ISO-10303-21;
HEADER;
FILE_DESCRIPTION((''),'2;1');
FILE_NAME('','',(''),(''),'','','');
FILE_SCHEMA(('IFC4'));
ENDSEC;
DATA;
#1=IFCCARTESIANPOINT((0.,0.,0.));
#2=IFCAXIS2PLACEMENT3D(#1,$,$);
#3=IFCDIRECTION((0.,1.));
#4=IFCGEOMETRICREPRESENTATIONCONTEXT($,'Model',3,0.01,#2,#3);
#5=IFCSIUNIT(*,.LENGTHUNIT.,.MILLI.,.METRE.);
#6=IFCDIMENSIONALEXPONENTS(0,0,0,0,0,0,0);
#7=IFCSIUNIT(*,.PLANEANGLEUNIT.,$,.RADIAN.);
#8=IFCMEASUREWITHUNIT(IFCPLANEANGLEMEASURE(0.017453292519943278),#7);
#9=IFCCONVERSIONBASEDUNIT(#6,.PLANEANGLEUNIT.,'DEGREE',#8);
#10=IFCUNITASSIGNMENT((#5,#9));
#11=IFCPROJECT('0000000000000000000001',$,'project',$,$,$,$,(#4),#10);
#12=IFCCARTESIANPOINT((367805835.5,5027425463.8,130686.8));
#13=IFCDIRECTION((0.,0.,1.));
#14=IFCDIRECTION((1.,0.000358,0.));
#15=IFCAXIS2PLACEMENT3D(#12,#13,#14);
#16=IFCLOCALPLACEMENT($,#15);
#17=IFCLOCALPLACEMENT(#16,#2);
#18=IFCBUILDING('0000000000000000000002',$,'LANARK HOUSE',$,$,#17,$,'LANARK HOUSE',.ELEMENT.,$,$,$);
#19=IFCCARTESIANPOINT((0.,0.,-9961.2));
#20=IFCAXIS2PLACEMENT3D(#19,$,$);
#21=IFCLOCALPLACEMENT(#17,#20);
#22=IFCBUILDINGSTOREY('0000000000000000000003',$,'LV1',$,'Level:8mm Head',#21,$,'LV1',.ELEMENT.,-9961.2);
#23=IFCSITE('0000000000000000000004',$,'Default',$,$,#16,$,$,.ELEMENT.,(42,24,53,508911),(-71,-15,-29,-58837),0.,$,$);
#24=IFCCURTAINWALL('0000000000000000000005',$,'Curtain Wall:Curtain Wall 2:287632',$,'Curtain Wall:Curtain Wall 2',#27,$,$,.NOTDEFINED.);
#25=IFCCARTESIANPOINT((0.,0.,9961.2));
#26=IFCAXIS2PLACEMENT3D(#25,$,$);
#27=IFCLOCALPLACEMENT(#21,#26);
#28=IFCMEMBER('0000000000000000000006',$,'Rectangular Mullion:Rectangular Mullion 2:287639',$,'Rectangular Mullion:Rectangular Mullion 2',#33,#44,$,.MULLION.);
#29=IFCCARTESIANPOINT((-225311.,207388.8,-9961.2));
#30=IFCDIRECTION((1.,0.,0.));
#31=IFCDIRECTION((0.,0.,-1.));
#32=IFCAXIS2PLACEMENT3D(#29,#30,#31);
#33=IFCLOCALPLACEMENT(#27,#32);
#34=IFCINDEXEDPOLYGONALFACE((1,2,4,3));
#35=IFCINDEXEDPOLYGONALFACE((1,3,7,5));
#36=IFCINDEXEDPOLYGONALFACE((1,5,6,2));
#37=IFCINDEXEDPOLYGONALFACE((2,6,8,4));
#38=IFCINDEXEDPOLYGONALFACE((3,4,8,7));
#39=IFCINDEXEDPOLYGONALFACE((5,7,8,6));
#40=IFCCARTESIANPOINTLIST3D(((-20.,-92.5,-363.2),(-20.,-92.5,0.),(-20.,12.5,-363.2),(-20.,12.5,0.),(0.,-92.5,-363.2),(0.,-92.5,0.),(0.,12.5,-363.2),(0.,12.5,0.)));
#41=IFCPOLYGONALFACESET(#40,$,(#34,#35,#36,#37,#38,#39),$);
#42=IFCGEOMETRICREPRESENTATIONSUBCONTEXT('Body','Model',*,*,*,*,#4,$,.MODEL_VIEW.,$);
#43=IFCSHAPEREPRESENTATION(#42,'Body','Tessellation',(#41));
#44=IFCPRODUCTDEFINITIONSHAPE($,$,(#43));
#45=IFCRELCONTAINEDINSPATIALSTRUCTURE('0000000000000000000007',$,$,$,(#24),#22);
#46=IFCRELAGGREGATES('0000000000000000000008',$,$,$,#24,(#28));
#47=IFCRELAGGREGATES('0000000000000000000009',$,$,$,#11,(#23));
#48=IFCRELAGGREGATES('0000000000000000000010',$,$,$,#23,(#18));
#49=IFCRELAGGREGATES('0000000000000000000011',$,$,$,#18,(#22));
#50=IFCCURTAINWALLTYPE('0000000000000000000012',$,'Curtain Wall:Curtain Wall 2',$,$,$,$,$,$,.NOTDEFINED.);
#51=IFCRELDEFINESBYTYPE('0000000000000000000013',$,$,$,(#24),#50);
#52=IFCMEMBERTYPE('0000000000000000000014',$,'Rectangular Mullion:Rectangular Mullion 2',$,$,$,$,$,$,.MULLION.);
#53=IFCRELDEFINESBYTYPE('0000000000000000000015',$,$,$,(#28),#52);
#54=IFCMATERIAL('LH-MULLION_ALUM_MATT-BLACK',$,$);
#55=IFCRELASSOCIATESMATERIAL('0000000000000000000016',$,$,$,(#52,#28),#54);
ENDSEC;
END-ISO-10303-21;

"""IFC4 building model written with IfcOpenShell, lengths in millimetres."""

from ifc_helpers import new_model, entity, si_unit, converted_unit, direction, frame, origin, place, context, subcontext, project, spatial, indexed_curve, outline, extrude, source, transform, mapped, material, type_object, type_shapes, element, aggregate, save


model = new_model("IFC4")

# Units and contexts
model_context = context("Model", 3, precision=0.01, world=origin(), true_north=direction((0.0, 1.0)))
body_context = subcontext(model_context, "Body", "Model", "MODEL_VIEW")
ifc_project = project(units=[si_unit("LENGTHUNIT", "METRE", prefix="MILLI"), converted_unit("PLANEANGLEUNIT", "DEGREE", entity("IfcPlaneAngleMeasure", 0.017453292519943278), si_unit("PLANEANGLEUNIT", "RADIAN"), dimensions=[0, 0, 0, 0, 0, 0, 0])], contexts=[model_context])

# Site, building, storey
site_placement = place(None, frame((367805835.5, 5027425463.8, 130686.8), z_axis=(0.0, 0.0, 1.0), x_axis=(1.0, 0.000358, 0.0)))
site = spatial("IfcSite", under=ifc_project, at=site_placement, Name="Default", CompositionType="ELEMENT", RefLatitude=(42, 24, 53, 508911), RefLongitude=(-71, -15, -29, -58837), RefElevation=0.0)
building_placement = place(site_placement, origin())
building = spatial("IfcBuilding", under=site, at=building_placement, Name="LANARK HOUSE", LongName="LANARK HOUSE", CompositionType="ELEMENT")
storey_placement = place(building_placement, frame((0.0, 0.0, -9961.2)))
storey = spatial("IfcBuildingStorey", under=building, at=storey_placement, Name="LV1", ObjectType="Level:8mm Head", LongName="LV1", CompositionType="ELEMENT", Elevation=-9961.2)

# Curtain wall
curtain_wall_type_1 = type_object("IfcCurtainWallType", Name="Curtain Wall:Curtain Wall 2", PredefinedType="NOTDEFINED")
curtain_wall_1_placement = place(storey_placement, frame((0.0, 0.0, 9961.2)))
curtain_wall_1 = element("IfcCurtainWall", 1, at=curtain_wall_1_placement, inside=storey, type_object=curtain_wall_type_1, Name="Curtain Wall:Curtain Wall 2:287632", ObjectType="Curtain Wall:Curtain Wall 2", PredefinedType="NOTDEFINED")
ifc_material_1 = material(Name="LH-MULLION_ALUM_MATT-BLACK")

# Member
member_type_1 = type_object("IfcMemberType", Name="Rectangular Mullion:Rectangular Mullion 2", PredefinedType="MULLION", material=ifc_material_1)
shared_shape_1 = source(origin(), body_context, "Body", "SweptSolid", [
    extrude(outline(indexed_curve([(-10.0, -52.5), (10.0, -52.5), (10.0, 52.5), (-10.0, 52.5), (-10.0, -52.5)], self_intersect=False)), frame((-10.0, -40.0, -363.2), z_axis=(0.0, 0.0, 1.0), x_axis=(-1.0, 0.0, 0.0)), (0.0, 0.0, 1.0), 363.2),
])
type_shapes(member_type_1, [shared_shape_1])
member_1_placement = place(curtain_wall_1_placement, frame((-225311.0, 207388.8, -9961.2), z_axis=(1.0, 0.0, 0.0), x_axis=(0.0, 0.0, -1.0)))
member_1 = element("IfcMember", 2, at=member_1_placement, type_object=member_type_1, material=ifc_material_1, Name="Rectangular Mullion:Rectangular Mullion 2:287639", ObjectType="Rectangular Mullion:Rectangular Mullion 2", PredefinedType="MULLION", context=body_context, shape_type="MappedRepresentation", body=[
    mapped(shared_shape_1, transform((0.0, 0.0, 0.0), scale=1.0)),
])
aggregate(curtain_wall_1, [member_1])

save(model, "model.ifc")
